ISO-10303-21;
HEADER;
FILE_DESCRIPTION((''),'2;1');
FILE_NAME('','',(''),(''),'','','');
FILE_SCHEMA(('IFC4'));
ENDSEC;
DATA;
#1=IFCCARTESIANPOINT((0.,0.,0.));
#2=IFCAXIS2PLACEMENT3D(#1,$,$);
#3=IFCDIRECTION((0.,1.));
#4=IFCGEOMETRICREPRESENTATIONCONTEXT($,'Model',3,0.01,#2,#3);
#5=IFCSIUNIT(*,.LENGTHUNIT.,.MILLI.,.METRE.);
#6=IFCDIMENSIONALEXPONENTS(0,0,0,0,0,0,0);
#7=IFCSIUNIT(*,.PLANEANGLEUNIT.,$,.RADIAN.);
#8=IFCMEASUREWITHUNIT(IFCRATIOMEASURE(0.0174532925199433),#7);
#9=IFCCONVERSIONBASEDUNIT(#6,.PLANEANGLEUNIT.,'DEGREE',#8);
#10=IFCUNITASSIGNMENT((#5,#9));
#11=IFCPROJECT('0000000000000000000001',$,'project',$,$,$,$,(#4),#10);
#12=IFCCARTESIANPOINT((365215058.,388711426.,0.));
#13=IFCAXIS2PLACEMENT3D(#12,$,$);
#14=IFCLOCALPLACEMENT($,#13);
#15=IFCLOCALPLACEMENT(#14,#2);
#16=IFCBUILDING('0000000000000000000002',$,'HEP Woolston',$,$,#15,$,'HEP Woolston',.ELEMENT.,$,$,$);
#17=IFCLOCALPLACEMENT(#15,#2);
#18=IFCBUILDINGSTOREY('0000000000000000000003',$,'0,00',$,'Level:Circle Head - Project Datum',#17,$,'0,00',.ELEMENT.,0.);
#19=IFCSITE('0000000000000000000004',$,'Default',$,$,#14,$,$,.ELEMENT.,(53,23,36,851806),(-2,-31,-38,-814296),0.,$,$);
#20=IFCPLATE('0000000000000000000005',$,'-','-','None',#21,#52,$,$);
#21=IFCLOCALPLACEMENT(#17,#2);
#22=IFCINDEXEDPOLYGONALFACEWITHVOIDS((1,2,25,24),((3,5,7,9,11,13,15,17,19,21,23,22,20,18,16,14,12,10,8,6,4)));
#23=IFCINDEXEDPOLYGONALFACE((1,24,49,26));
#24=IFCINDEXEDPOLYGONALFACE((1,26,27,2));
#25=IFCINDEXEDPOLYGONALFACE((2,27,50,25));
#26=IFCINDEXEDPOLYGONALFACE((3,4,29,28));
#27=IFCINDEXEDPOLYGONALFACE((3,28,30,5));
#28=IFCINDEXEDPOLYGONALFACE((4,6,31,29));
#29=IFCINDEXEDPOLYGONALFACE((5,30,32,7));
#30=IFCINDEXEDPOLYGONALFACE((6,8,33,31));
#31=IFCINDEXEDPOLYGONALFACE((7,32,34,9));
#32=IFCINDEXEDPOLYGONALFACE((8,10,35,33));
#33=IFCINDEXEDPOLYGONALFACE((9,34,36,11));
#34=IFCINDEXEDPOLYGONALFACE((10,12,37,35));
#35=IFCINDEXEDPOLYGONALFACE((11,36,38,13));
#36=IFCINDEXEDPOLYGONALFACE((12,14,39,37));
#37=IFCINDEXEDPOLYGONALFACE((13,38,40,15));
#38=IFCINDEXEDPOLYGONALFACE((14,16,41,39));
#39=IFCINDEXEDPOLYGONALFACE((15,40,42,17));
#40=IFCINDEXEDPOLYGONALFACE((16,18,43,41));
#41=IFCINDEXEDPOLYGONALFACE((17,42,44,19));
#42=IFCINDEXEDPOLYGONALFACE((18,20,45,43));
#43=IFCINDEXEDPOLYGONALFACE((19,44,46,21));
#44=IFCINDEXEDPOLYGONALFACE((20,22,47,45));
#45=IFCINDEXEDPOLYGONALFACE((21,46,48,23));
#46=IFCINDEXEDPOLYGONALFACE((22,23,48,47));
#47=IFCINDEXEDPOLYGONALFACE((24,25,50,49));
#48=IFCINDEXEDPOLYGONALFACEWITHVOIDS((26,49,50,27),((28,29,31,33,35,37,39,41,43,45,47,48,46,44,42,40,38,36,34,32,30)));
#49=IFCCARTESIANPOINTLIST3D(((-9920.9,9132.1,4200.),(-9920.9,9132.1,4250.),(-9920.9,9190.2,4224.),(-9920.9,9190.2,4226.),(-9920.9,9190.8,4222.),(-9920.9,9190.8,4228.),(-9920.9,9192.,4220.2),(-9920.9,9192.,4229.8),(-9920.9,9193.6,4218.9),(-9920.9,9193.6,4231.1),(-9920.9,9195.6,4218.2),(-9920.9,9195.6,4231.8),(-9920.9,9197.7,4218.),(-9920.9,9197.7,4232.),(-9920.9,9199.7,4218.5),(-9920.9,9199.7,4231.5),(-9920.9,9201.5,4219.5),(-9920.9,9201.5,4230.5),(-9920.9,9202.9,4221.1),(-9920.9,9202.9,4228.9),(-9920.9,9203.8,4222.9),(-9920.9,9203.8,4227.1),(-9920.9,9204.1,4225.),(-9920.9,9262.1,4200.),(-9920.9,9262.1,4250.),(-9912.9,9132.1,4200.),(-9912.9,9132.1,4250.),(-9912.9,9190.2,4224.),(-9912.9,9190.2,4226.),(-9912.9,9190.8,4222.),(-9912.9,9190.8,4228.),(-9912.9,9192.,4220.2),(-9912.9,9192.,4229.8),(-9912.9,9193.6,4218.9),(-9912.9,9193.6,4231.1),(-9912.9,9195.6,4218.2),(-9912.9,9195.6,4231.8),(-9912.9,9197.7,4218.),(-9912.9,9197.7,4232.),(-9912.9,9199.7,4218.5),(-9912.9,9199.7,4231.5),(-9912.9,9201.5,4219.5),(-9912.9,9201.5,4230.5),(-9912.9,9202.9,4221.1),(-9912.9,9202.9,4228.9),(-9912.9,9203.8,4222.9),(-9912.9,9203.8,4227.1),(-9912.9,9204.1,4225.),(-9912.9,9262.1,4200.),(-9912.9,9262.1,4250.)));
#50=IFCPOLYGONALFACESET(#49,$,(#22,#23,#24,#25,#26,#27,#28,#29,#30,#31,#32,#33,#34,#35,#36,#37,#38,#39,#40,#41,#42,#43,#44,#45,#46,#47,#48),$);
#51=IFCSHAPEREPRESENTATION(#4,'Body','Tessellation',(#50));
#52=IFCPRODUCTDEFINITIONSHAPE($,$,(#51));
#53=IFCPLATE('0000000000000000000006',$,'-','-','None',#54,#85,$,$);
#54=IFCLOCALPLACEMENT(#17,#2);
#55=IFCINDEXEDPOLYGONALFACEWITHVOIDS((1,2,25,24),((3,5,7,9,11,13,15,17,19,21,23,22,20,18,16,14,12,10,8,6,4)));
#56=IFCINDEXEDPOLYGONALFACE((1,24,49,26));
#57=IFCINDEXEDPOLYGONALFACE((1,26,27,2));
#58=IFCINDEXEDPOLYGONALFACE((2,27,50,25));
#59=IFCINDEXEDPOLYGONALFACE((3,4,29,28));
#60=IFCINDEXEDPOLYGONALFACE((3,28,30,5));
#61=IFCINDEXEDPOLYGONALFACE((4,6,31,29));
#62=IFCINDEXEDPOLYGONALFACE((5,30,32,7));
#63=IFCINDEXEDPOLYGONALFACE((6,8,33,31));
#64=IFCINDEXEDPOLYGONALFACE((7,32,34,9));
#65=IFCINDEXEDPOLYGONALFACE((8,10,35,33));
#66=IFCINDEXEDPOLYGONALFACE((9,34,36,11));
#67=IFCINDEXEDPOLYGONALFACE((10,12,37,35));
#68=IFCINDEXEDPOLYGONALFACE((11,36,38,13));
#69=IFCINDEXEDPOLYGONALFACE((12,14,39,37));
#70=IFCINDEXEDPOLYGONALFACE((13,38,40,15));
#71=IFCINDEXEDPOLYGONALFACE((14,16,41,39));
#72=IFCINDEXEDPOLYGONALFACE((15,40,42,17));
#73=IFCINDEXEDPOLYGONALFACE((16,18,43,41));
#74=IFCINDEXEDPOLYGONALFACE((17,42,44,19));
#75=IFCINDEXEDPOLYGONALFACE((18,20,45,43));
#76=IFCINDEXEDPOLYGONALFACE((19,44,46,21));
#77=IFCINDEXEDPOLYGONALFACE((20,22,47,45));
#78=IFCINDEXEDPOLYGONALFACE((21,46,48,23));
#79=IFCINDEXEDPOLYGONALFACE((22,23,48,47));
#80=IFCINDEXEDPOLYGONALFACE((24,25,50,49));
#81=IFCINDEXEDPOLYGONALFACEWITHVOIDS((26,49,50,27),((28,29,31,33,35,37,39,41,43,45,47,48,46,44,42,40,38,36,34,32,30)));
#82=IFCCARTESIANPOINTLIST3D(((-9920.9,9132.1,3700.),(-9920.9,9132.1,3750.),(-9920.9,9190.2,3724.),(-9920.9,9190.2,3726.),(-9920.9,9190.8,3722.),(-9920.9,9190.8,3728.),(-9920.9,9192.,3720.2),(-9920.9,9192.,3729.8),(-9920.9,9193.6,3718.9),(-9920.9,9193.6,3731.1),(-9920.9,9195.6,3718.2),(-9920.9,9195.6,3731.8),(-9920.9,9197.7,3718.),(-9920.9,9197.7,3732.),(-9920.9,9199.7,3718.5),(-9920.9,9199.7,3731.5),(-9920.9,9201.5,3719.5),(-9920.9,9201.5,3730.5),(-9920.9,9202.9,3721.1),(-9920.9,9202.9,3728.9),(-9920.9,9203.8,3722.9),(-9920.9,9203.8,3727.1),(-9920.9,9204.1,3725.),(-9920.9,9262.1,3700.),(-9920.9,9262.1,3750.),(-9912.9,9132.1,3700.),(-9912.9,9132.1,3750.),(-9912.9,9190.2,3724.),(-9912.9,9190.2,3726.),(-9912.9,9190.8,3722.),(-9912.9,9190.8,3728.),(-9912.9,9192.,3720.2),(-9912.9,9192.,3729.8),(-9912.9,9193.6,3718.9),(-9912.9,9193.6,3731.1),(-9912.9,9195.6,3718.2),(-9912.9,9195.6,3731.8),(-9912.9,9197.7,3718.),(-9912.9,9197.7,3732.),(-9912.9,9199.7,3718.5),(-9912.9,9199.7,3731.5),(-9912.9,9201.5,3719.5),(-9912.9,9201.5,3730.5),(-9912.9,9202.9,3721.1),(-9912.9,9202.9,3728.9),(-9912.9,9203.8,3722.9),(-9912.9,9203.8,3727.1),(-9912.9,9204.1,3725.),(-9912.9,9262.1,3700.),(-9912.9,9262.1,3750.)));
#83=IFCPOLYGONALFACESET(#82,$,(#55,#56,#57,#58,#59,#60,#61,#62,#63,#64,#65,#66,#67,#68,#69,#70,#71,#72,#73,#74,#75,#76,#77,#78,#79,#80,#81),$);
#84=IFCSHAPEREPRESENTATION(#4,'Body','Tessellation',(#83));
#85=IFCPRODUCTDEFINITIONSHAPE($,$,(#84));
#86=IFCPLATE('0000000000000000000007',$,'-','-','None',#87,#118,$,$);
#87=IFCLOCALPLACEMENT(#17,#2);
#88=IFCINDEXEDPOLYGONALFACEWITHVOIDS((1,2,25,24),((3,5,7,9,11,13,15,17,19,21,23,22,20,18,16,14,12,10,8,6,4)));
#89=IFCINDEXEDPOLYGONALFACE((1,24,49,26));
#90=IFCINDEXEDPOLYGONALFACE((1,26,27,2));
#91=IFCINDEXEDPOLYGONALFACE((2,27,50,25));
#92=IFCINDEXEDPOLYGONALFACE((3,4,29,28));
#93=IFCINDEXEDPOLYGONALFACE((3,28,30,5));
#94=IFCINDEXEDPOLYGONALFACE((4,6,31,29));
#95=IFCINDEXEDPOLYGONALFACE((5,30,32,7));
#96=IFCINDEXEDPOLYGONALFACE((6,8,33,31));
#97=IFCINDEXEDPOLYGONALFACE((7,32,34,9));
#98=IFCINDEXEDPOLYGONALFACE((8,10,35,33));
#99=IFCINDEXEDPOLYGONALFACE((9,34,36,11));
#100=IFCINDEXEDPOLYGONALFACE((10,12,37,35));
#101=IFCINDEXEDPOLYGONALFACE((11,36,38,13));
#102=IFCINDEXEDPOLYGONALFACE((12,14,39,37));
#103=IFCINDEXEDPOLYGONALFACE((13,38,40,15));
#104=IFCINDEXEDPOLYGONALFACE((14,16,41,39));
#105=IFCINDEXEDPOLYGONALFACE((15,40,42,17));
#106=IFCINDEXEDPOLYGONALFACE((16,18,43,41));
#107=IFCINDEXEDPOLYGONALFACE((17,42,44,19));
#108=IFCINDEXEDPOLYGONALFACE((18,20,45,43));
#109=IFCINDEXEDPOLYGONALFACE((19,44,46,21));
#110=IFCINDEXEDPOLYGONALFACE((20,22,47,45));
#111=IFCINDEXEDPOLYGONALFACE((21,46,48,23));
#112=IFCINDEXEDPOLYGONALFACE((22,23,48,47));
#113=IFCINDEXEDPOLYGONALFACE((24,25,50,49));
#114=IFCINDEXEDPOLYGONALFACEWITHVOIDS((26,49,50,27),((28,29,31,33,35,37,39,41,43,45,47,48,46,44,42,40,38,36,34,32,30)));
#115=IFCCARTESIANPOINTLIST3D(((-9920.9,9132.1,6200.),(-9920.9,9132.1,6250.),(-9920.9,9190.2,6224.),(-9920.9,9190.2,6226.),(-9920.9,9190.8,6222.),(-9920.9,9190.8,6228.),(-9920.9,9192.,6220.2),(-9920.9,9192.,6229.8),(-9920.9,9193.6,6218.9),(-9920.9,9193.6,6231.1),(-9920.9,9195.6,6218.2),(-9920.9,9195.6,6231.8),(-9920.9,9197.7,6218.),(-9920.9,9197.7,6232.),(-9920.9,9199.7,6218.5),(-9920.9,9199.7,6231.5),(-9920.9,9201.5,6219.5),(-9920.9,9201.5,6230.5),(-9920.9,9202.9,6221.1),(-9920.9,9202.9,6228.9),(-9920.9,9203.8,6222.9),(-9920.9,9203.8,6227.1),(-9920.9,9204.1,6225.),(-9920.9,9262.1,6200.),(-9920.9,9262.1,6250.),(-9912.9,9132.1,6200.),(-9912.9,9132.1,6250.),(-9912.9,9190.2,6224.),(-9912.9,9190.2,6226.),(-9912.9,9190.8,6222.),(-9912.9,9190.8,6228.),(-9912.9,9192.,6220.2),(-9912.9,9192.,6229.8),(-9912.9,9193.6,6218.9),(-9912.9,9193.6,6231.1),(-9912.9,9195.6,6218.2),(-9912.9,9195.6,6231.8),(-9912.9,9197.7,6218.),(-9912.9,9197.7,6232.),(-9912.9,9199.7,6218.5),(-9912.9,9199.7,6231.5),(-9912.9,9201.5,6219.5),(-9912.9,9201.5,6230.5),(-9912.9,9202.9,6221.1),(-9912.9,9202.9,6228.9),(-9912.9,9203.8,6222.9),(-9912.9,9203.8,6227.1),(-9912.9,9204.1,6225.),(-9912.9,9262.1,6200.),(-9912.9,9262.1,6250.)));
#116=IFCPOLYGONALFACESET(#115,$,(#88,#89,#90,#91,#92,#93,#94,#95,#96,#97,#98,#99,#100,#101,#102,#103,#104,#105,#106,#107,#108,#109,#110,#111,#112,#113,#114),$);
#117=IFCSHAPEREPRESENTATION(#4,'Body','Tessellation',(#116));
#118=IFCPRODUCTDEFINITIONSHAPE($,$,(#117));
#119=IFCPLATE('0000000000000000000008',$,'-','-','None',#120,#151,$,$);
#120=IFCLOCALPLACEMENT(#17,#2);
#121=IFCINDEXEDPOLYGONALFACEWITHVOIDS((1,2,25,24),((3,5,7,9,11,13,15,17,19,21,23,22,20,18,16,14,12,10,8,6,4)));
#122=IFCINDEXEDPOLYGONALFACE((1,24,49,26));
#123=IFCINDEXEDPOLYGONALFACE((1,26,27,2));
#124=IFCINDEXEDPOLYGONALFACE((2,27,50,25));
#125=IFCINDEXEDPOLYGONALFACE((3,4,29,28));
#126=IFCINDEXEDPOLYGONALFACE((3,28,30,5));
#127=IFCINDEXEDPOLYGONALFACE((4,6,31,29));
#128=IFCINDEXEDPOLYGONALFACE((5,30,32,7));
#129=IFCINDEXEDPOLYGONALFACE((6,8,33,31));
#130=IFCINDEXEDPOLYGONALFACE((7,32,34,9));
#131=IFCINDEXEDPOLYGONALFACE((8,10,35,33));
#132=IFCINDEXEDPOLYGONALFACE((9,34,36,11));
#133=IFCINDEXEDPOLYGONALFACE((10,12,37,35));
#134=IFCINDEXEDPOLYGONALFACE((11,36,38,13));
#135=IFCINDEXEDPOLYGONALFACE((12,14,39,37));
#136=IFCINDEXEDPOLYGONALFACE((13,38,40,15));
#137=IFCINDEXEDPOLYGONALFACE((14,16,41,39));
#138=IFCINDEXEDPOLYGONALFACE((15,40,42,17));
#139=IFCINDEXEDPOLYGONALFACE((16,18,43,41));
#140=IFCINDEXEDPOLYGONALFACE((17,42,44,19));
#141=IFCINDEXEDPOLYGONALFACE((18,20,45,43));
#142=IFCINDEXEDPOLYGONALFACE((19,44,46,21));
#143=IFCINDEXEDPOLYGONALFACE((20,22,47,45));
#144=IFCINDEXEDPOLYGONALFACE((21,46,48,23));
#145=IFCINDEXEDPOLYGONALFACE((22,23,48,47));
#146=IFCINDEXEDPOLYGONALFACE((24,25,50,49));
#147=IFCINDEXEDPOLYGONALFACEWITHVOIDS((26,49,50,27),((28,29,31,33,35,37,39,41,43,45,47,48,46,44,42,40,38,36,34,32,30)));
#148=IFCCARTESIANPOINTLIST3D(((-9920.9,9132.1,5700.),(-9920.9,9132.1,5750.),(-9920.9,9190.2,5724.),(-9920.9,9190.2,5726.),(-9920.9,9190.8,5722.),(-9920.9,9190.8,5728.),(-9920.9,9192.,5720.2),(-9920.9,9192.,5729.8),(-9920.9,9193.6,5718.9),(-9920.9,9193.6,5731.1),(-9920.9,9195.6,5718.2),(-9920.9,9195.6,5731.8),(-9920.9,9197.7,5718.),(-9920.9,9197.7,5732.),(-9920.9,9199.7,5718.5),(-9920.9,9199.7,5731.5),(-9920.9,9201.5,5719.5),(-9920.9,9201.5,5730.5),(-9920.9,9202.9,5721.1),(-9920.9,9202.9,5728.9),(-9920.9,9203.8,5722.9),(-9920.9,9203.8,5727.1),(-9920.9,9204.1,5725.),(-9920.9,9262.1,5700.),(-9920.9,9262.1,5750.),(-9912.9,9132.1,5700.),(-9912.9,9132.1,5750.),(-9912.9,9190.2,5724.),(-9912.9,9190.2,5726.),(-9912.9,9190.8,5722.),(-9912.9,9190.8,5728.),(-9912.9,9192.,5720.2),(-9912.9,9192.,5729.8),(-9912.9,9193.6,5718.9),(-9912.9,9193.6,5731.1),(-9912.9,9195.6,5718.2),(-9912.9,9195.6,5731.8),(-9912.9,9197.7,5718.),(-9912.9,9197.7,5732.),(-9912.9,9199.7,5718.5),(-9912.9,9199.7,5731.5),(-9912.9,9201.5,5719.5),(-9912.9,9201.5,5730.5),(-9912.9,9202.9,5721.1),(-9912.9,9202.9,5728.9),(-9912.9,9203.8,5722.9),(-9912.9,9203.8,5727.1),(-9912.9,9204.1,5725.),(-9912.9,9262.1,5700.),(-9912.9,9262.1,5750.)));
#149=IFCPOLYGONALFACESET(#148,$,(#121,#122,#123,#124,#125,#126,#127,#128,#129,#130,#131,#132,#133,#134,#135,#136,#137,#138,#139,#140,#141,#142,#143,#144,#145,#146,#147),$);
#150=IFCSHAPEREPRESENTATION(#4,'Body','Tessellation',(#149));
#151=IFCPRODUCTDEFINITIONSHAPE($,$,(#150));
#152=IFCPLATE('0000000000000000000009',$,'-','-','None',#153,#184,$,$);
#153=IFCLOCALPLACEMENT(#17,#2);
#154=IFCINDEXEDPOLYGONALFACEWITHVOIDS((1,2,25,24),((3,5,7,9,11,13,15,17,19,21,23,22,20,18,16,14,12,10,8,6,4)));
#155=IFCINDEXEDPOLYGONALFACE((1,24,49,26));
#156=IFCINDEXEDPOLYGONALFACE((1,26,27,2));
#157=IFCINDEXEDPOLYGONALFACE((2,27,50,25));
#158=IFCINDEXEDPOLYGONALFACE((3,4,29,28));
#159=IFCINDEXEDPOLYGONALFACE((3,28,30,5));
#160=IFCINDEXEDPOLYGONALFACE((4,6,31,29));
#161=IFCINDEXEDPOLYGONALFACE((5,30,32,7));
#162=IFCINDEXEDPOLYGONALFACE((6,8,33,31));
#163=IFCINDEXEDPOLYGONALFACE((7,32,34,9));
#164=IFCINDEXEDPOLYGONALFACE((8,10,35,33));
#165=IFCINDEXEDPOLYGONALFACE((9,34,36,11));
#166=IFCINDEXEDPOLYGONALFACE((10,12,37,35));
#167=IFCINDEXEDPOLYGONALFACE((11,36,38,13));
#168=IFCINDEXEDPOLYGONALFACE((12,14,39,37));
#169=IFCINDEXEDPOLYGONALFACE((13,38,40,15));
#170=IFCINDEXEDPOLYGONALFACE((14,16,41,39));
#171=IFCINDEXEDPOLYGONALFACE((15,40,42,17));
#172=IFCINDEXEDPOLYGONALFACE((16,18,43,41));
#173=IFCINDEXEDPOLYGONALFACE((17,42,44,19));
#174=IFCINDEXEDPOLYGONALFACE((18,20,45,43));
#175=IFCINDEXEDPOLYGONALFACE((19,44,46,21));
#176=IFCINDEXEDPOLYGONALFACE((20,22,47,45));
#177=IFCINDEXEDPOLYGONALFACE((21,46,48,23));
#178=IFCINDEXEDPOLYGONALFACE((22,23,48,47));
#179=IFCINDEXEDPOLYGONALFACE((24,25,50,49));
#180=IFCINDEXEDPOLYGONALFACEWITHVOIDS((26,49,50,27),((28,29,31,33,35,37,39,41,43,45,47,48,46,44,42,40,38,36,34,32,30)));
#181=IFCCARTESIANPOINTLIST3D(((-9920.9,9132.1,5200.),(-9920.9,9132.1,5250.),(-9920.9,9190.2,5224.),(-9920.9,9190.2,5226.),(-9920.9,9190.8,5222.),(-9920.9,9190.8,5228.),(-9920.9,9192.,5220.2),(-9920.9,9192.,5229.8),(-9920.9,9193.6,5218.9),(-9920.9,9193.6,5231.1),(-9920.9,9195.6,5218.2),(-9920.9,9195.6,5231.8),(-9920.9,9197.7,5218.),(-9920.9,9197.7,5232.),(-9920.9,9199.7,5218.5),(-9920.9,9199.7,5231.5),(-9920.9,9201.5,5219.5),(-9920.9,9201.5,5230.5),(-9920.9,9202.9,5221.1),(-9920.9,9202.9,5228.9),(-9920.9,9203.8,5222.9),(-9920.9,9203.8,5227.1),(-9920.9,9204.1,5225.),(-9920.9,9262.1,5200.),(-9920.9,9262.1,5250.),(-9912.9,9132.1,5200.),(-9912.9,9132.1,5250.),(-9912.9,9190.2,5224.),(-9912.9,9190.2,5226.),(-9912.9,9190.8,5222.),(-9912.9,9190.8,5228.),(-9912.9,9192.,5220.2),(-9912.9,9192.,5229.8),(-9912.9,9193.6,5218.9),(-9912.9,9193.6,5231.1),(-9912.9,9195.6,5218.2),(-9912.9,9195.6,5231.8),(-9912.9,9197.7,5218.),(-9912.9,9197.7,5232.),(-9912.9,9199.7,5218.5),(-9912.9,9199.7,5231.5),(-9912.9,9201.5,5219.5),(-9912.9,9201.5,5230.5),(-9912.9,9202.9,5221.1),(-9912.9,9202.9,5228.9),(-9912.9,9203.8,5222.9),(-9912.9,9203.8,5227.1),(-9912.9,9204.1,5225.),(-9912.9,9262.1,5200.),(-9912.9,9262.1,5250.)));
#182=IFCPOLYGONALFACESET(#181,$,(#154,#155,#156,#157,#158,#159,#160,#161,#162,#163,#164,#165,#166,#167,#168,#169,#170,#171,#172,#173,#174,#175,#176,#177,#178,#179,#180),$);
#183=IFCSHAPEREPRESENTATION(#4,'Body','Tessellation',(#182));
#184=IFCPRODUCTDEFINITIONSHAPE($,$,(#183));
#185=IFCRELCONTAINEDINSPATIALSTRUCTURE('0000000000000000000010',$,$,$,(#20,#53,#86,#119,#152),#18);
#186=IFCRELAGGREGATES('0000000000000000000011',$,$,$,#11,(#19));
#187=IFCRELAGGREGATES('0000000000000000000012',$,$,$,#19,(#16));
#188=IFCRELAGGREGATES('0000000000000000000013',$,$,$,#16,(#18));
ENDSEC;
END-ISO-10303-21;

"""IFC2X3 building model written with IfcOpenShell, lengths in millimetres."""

from ifc_helpers import new_model, entity, si_unit, converted_unit, direction, frame, origin, origin_with_axes, origin_2d_with_axis, place, context, project, spatial, polyline, circle, outline, extrude, element, save


model = new_model("IFC2X3")

# Units and contexts
model_context = context("Model", 3, precision=0.01, world=origin(), true_north=direction((0.0, 1.0)))
ifc_project = project(units=[si_unit("LENGTHUNIT", "METRE", prefix="MILLI"), converted_unit("PLANEANGLEUNIT", "DEGREE", entity("IfcRatioMeasure", 0.0174532925199433), si_unit("PLANEANGLEUNIT", "RADIAN"), dimensions=[0, 0, 0, 0, 0, 0, 0])], contexts=[model_context])

# Site, building, storey
site_placement = place(None, frame((365215058.0, 388711426.0, 0.0)))
site = spatial("IfcSite", under=ifc_project, at=site_placement, Name="Default", CompositionType="ELEMENT", RefLatitude=(53, 23, 36, 851806), RefLongitude=(-2, -31, -38, -814296), RefElevation=0.0)
building_placement = place(site_placement, origin())
building = spatial("IfcBuilding", under=site, at=building_placement, Name="HEP Woolston", LongName="HEP Woolston", CompositionType="ELEMENT")
storey_placement = place(building_placement, origin())
storey = spatial("IfcBuildingStorey", under=building, at=storey_placement, Name="0,00", ObjectType="Level:Circle Head - Project Datum", LongName="0,00", CompositionType="ELEMENT", Elevation=0.0)

# Plates, openings
plate_1_placement = place(storey_placement, frame((-9920.9, 9132.1, 4250.0), z_axis=(1.0, 0.0, 0.0), x_axis=(0.0, 1.0, 0.0)))
plate_1 = element("IfcPlate", 1, at=plate_1_placement, inside=storey, Name="-", Description="-", ObjectType="None", context=model_context, shape_type="SweptSolid", body=[
    extrude(outline(polyline([(0.0, -50.0), (130.0, -50.0), (130.0, 0.0), (0.0, 0.0), (0.0, -50.0)])), origin_with_axes(), (0.0, 0.0, 1.0), 8.0),
])
opening_1_placement = place(plate_1_placement, frame((65.0, -25.0, 8.5), z_axis=(0.0, 0.0, -1.0), x_axis=(1.0, 0.0, 0.0)))
element("IfcOpeningElement", 2, at=opening_1_placement, cuts=plate_1, ObjectType="Opening", context=model_context, shape_type="SweptSolid", body=[
    extrude(circle(Radius=7.0, at=origin_2d_with_axis()), origin(), (0.0, 0.0, 1.0), 9.0),
])
plate_2_placement = place(storey_placement, frame((-9920.9, 9132.1, 3750.0), z_axis=(1.0, 0.0, 0.0), x_axis=(0.0, 1.0, 0.0)))
plate_2 = element("IfcPlate", 3, at=plate_2_placement, inside=storey, Name="-", Description="-", ObjectType="None", context=model_context, shape_type="SweptSolid", body=[
    extrude(outline(polyline([(0.0, -50.0), (130.0, -50.0), (130.0, 0.0), (0.0, 0.0), (0.0, -50.0)])), origin_with_axes(), (0.0, 0.0, 1.0), 8.0),
])
opening_2_placement = place(plate_2_placement, frame((65.0, -25.0, 8.5), z_axis=(0.0, 0.0, -1.0), x_axis=(1.0, 0.0, 0.0)))
element("IfcOpeningElement", 4, at=opening_2_placement, cuts=plate_2, ObjectType="Opening", context=model_context, shape_type="SweptSolid", body=[
    extrude(circle(Radius=7.0, at=origin_2d_with_axis()), origin(), (0.0, 0.0, 1.0), 9.0),
])
plate_3_placement = place(storey_placement, frame((-9920.9, 9132.1, 6250.0), z_axis=(1.0, 0.0, 0.0), x_axis=(0.0, 1.0, 0.0)))
plate_3 = element("IfcPlate", 5, at=plate_3_placement, inside=storey, Name="-", Description="-", ObjectType="None", context=model_context, shape_type="SweptSolid", body=[
    extrude(outline(polyline([(0.0, -50.0), (130.0, -50.0), (130.0, 0.0), (0.0, 0.0), (0.0, -50.0)])), origin_with_axes(), (0.0, 0.0, 1.0), 8.0),
])
opening_3_placement = place(plate_3_placement, frame((65.0, -25.0, 8.5), z_axis=(0.0, 0.0, -1.0), x_axis=(1.0, 0.0, 0.0)))
element("IfcOpeningElement", 6, at=opening_3_placement, cuts=plate_3, ObjectType="Opening", context=model_context, shape_type="SweptSolid", body=[
    extrude(circle(Radius=7.0, at=origin_2d_with_axis()), origin(), (0.0, 0.0, 1.0), 9.0),
])
plate_4_placement = place(storey_placement, frame((-9920.9, 9132.1, 5750.0), z_axis=(1.0, 0.0, 0.0), x_axis=(0.0, 1.0, 0.0)))
plate_4 = element("IfcPlate", 7, at=plate_4_placement, inside=storey, Name="-", Description="-", ObjectType="None", context=model_context, shape_type="SweptSolid", body=[
    extrude(outline(polyline([(0.0, -50.0), (130.0, -50.0), (130.0, 0.0), (0.0, 0.0), (0.0, -50.0)])), origin_with_axes(), (0.0, 0.0, 1.0), 8.0),
])
opening_4_placement = place(plate_4_placement, frame((65.0, -25.0, 8.5), z_axis=(0.0, 0.0, -1.0), x_axis=(1.0, 0.0, 0.0)))
element("IfcOpeningElement", 8, at=opening_4_placement, cuts=plate_4, ObjectType="Opening", context=model_context, shape_type="SweptSolid", body=[
    extrude(circle(Radius=7.0, at=origin_2d_with_axis()), origin(), (0.0, 0.0, 1.0), 9.0),
])
plate_5_placement = place(storey_placement, frame((-9920.9, 9132.1, 5250.0), z_axis=(1.0, 0.0, 0.0), x_axis=(0.0, 1.0, 0.0)))
plate_5 = element("IfcPlate", 9, at=plate_5_placement, inside=storey, Name="-", Description="-", ObjectType="None", context=model_context, shape_type="SweptSolid", body=[
    extrude(outline(polyline([(0.0, -50.0), (130.0, -50.0), (130.0, 0.0), (0.0, 0.0), (0.0, -50.0)])), origin_with_axes(), (0.0, 0.0, 1.0), 8.0),
])
opening_5_placement = place(plate_5_placement, frame((65.0, -25.0, 8.5), z_axis=(0.0, 0.0, -1.0), x_axis=(1.0, 0.0, 0.0)))
element("IfcOpeningElement", 10, at=opening_5_placement, cuts=plate_5, ObjectType="Opening", context=model_context, shape_type="SweptSolid", body=[
    extrude(circle(Radius=7.0, at=origin_2d_with_axis()), origin(), (0.0, 0.0, 1.0), 9.0),
])

save(model, "model.ifc")
